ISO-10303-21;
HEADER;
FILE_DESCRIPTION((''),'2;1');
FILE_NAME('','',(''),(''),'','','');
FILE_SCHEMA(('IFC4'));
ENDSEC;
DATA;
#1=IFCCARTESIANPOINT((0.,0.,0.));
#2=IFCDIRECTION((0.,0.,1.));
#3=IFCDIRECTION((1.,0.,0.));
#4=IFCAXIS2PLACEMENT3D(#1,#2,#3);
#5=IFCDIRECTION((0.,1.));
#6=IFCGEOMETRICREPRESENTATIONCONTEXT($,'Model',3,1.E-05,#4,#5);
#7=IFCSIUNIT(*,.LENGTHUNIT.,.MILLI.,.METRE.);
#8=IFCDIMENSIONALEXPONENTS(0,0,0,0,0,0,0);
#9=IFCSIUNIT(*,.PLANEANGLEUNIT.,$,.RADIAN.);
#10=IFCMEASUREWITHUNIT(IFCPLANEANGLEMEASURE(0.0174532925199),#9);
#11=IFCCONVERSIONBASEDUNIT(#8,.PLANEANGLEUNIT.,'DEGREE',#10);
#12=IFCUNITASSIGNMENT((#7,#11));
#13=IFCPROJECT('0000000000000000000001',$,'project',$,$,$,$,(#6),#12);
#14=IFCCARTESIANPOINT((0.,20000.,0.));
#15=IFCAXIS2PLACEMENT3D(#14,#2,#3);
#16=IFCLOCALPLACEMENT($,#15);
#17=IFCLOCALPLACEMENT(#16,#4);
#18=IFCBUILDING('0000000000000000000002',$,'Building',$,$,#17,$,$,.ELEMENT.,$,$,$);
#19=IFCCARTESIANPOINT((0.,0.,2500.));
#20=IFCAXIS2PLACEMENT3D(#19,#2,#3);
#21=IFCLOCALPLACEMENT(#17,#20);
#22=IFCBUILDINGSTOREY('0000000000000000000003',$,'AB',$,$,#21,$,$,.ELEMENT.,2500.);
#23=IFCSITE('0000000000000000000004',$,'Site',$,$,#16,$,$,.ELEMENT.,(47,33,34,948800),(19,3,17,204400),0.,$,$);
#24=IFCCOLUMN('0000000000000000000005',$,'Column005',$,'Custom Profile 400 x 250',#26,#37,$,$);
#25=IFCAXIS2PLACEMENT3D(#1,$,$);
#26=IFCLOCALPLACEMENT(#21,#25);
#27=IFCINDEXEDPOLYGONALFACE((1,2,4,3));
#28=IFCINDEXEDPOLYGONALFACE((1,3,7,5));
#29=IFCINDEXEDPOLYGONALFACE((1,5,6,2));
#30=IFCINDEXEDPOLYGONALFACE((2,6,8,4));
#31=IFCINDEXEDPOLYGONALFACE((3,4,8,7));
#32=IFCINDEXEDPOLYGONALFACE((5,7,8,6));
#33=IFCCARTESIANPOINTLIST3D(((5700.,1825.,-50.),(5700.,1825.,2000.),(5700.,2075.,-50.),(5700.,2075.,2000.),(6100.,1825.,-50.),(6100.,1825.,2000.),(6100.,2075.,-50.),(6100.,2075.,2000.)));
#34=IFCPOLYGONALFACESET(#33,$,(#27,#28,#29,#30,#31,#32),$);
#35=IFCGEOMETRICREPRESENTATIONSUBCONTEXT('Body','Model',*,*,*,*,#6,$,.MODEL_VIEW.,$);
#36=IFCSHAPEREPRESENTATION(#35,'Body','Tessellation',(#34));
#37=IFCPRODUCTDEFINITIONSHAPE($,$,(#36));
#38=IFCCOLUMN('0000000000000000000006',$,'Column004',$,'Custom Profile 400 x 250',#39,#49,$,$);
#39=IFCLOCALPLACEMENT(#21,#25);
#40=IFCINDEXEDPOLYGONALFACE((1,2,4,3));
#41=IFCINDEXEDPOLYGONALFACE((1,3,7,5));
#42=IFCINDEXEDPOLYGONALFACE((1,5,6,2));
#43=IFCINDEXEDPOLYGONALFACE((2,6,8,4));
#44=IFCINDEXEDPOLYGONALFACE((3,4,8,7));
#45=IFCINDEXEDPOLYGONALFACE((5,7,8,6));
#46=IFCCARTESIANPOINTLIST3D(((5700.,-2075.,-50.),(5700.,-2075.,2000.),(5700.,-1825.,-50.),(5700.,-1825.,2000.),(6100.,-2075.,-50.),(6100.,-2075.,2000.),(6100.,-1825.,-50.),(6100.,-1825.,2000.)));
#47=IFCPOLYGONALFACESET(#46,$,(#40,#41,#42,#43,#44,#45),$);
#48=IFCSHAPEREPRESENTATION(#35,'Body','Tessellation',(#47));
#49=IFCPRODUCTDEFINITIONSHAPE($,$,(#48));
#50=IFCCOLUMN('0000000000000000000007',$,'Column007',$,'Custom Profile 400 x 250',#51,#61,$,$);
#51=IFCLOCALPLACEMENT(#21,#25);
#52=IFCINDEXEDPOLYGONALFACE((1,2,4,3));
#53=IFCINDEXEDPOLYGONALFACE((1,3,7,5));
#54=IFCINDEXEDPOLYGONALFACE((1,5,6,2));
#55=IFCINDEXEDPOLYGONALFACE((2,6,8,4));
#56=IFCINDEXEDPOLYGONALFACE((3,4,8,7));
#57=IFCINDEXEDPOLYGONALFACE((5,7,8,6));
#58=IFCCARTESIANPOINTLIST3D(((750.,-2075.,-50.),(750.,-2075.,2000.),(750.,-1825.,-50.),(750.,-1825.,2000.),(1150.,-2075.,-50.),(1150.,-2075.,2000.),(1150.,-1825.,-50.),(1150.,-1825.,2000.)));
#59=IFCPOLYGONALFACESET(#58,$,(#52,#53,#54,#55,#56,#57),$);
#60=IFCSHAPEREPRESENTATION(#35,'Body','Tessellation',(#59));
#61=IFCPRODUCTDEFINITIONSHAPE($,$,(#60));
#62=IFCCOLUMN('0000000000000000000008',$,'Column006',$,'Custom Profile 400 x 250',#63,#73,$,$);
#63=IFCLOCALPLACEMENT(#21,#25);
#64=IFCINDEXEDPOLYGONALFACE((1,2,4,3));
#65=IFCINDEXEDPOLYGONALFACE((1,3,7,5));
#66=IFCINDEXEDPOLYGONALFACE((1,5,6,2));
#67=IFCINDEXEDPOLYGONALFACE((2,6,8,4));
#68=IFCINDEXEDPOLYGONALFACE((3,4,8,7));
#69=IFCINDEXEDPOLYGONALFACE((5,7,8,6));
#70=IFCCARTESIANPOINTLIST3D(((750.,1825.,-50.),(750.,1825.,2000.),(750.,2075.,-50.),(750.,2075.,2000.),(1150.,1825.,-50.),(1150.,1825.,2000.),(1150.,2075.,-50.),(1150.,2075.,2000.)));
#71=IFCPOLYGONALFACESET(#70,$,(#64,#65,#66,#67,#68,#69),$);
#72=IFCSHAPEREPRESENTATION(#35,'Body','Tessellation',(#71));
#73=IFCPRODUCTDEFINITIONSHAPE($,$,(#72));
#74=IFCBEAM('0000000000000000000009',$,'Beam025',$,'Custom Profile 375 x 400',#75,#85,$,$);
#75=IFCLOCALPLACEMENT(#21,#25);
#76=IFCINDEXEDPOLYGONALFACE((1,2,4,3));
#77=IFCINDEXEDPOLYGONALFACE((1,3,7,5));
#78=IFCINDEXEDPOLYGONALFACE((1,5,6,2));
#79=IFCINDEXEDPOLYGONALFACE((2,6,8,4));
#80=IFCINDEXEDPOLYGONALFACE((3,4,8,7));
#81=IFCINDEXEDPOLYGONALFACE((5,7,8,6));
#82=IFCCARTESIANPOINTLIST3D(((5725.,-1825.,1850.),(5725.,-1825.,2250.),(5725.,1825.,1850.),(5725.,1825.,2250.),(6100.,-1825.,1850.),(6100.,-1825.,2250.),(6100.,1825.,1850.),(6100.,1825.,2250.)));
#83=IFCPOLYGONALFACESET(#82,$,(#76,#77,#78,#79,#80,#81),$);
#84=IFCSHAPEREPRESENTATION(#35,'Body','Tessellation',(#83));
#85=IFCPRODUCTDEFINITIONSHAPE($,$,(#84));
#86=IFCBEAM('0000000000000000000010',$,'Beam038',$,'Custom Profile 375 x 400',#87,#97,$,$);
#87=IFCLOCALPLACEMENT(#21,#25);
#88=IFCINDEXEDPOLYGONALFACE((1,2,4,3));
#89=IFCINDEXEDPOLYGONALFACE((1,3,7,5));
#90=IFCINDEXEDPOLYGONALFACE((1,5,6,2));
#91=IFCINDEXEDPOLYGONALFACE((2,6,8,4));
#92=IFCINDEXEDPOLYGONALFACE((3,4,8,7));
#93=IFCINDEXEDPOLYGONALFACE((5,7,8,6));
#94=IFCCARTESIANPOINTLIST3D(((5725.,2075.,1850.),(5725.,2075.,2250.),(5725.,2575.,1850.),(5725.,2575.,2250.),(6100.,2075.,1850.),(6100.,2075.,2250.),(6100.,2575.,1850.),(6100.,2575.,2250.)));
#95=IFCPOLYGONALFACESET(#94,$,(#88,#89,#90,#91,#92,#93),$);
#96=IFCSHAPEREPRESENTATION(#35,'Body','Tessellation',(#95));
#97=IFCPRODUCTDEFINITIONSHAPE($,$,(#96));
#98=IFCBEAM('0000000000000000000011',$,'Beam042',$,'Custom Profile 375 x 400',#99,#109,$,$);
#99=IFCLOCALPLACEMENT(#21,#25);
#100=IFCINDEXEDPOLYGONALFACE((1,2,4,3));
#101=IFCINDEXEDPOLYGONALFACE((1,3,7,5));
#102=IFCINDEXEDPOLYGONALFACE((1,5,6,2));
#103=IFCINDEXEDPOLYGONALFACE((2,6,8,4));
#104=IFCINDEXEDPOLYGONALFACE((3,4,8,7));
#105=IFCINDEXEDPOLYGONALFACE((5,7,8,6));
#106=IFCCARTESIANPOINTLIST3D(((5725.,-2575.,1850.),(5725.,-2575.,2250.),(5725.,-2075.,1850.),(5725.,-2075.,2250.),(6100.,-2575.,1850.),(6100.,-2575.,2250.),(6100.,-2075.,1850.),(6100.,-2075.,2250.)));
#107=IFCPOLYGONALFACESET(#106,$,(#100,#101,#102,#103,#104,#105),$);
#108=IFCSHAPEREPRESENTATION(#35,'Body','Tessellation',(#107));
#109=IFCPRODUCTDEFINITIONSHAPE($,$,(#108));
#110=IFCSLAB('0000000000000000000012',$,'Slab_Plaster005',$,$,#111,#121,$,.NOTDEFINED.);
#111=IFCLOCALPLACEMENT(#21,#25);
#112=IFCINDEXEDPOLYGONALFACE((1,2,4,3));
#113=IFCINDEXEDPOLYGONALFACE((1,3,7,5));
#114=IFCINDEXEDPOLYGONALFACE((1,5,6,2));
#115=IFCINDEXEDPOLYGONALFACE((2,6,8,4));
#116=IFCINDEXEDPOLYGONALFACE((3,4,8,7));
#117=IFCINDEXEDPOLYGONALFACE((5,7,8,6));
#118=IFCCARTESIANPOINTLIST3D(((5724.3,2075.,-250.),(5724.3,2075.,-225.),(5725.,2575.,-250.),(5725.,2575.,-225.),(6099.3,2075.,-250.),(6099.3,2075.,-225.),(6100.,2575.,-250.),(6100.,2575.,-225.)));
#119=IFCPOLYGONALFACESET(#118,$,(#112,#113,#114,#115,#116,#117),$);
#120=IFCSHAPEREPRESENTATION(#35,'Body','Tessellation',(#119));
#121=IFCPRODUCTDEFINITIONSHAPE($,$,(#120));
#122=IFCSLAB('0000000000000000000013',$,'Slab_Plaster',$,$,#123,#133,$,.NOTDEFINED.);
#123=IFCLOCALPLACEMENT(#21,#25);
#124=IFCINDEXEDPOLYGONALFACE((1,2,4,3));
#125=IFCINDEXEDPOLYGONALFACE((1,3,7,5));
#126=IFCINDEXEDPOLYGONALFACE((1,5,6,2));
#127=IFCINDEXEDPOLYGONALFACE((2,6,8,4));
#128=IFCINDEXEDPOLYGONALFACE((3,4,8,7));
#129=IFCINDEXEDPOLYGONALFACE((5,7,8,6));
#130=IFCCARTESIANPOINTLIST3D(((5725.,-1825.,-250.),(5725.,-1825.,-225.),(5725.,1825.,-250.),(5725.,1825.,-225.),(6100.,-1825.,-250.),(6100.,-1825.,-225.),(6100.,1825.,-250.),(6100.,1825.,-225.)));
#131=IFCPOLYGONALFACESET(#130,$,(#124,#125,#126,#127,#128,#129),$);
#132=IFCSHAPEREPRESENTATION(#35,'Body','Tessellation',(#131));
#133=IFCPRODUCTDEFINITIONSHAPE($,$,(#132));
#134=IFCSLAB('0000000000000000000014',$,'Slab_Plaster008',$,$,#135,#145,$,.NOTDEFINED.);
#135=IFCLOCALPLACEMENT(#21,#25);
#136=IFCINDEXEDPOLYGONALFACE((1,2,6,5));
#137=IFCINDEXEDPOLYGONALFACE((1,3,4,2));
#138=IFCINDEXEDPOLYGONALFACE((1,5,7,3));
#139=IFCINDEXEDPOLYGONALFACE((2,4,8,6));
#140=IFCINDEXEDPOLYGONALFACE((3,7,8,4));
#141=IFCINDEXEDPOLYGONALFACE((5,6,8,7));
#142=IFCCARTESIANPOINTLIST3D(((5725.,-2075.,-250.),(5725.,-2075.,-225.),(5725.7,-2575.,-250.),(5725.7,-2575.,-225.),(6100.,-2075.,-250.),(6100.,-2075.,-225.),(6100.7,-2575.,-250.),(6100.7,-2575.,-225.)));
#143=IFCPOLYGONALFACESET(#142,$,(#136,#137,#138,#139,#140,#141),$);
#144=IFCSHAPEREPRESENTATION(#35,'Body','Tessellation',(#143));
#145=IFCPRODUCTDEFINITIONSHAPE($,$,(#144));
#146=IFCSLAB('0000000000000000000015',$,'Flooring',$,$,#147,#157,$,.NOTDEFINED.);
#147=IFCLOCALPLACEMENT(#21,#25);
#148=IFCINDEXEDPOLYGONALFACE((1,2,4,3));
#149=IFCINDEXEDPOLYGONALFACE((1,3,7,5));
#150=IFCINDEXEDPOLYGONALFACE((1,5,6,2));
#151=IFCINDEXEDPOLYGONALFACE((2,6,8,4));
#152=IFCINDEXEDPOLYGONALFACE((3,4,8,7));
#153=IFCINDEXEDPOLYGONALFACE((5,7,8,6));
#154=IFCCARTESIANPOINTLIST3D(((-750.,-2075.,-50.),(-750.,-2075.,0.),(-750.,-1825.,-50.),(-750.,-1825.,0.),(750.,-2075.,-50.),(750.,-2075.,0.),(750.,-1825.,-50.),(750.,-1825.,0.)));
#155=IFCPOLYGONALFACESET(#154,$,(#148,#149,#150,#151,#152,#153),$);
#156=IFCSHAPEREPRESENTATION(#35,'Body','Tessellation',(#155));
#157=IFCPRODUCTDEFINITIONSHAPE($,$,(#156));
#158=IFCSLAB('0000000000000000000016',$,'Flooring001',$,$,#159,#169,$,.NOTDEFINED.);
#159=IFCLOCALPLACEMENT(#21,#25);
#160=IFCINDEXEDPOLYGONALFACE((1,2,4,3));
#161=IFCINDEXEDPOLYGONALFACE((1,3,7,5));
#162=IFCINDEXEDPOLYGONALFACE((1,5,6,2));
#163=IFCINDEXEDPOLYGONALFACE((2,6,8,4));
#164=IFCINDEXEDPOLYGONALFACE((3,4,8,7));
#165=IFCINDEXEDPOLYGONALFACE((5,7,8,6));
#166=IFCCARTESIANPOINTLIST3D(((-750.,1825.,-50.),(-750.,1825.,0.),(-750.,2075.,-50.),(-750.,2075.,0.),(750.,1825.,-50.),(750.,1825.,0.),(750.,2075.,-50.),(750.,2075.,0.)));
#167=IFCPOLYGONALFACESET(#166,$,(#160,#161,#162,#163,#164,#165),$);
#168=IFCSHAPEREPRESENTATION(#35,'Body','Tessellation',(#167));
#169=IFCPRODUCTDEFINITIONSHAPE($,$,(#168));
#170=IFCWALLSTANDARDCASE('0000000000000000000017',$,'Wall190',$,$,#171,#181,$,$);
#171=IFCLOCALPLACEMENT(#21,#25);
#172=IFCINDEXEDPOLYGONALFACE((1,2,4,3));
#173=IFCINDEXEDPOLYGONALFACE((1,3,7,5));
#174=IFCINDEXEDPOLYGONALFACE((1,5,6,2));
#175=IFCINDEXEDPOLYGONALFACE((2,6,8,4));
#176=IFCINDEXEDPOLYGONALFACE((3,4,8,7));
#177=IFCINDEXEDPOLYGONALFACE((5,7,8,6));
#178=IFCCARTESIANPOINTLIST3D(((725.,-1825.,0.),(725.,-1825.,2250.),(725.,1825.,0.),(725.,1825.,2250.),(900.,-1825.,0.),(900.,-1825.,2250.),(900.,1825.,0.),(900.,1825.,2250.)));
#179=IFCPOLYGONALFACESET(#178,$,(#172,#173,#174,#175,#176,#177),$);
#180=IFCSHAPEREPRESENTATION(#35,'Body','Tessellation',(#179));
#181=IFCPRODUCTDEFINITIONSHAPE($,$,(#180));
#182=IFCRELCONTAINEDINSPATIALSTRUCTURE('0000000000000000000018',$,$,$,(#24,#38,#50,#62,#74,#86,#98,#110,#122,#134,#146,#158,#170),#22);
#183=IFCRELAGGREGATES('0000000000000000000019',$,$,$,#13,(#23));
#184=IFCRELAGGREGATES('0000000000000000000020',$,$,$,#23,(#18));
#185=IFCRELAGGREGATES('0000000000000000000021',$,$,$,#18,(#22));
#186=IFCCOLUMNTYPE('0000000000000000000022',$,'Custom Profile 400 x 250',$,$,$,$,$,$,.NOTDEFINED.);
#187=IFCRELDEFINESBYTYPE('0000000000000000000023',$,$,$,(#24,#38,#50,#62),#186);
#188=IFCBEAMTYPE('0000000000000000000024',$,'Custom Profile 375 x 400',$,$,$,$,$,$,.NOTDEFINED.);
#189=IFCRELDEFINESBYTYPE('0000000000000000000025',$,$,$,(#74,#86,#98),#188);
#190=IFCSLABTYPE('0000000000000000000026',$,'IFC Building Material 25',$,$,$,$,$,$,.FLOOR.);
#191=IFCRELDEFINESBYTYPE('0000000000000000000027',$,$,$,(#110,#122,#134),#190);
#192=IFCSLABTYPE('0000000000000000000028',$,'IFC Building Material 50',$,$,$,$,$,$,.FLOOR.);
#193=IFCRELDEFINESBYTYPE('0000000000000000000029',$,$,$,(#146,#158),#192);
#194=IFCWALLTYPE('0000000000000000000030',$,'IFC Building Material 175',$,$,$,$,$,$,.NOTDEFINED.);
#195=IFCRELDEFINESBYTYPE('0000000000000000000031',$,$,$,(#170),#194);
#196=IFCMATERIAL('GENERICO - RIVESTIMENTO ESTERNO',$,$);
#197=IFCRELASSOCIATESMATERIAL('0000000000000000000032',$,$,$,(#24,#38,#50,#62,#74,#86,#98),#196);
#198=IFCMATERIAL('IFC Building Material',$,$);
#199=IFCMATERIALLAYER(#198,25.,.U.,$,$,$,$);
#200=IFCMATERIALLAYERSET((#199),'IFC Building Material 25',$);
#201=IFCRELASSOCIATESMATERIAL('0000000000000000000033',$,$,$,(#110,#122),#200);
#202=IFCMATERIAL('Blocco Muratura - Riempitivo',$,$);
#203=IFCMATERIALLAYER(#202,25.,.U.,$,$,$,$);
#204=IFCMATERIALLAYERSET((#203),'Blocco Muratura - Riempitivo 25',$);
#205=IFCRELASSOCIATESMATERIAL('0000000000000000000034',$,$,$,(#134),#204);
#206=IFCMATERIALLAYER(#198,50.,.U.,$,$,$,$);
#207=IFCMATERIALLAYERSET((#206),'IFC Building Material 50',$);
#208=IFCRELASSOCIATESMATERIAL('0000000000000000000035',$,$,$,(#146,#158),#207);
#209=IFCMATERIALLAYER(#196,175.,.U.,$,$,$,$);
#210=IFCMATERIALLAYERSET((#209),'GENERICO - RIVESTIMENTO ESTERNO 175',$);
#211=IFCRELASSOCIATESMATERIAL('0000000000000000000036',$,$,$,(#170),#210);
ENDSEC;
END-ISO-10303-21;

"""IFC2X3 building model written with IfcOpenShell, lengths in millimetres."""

from ifc_helpers import new_model, entity, si_unit, converted_unit, direction, frame, frame_2d, origin_with_axes, origin_2d_with_axis, place, context, subcontext, project, spatial, polyline, rectangle, outline, extrude, material, layer, layer_set, layer_usage, type_object, element, save


model = new_model("IFC2X3")

# Units and contexts
model_context = context("Model", 3, precision=1e-05, world=origin_with_axes(), true_north=direction((0.0, 1.0)))
body_context = subcontext(model_context, "Body", "Model", "MODEL_VIEW")
ifc_project = project(units=[si_unit("LENGTHUNIT", "METRE", prefix="MILLI"), converted_unit("PLANEANGLEUNIT", "DEGREE", entity("IfcPlaneAngleMeasure", 0.0174532925199), si_unit("PLANEANGLEUNIT", "RADIAN"), dimensions=[0, 0, 0, 0, 0, 0, 0])], contexts=[model_context])

# Site, building, storey
site_placement = place(None, frame((0.0, 20000.0, 0.0), z_axis=(0.0, 0.0, 1.0), x_axis=(1.0, 0.0, 0.0)))
site = spatial("IfcSite", under=ifc_project, at=site_placement, Name="Site", CompositionType="ELEMENT", RefLatitude=(47, 33, 34, 948800), RefLongitude=(19, 3, 17, 204400), RefElevation=0.0)
building_placement = place(site_placement, origin_with_axes())
building = spatial("IfcBuilding", under=site, at=building_placement, Name="Building", CompositionType="ELEMENT")
storey_placement = place(building_placement, frame((0.0, 0.0, 2500.0), z_axis=(0.0, 0.0, 1.0), x_axis=(1.0, 0.0, 0.0)))
storey = spatial("IfcBuildingStorey", under=building, at=storey_placement, Name="AB", CompositionType="ELEMENT", Elevation=2500.0)

# Columns
ifc_material_1 = material(Name="GENERICO - RIVESTIMENTO ESTERNO")
column_type = type_object("IfcColumnType", Name="Custom Profile 400 x 250", PredefinedType="NOTDEFINED")
for number, where, z_axis, x_axis, name in (
    (1, (5900.0, 1950.0, -50.0), (0.0, 0.0, 1.0), (1.0, 0.0, 0.0), "Column005"),
    (2, (5900.0, -1950.0, -50.0), (0.0, 0.0, 1.0), (1.0, 0.0, 0.0), "Column004"),
    (3, (950.0, -1950.0, -50.0), (0.0, 0.0, 1.0), (1.0, 0.0, 0.0), "Column007"),
    (4, (950.0, 1950.0, -50.0), (0.0, 0.0, 1.0), (1.0, 0.0, 0.0), "Column006"),
):
    element("IfcColumn", number, at=place(storey_placement, frame(where, z_axis=z_axis, x_axis=x_axis)), inside=storey, type_object=column_type, material=ifc_material_1, Name=name, ObjectType="Custom Profile 400 x 250", context=body_context, shape_type="SweptSolid", body=[
        extrude(rectangle(XDim=400.0, YDim=250.0, at=origin_2d_with_axis()), origin_with_axes(), (0.0, 0.0, 1.0), 2050.0),
    ])

# Beams
beam_type = type_object("IfcBeamType", Name="Custom Profile 375 x 400", PredefinedType="NOTDEFINED")
beam_placement = place(storey_placement, frame((5912.5, -1825.0, 2250.0), z_axis=(0.0, 0.0, 1.0), x_axis=(1.0, 0.0, 0.0)))
element("IfcBeam", 5, at=beam_placement, inside=storey, type_object=beam_type, material=ifc_material_1, Name="Beam025", ObjectType="Custom Profile 375 x 400", context=body_context, shape_type="SweptSolid", body=[
    extrude(rectangle(XDim=400.0, YDim=375.0, at=frame_2d((-200.0, 0.0), x_axis=(1.0, 0.0))), frame((0.0, 0.0, 0.0), z_axis=(0.0, 1.0, 0.0), x_axis=(0.0, 0.0, 1.0)), (0.0, 0.0, 1.0), 3650.0),
])
for number, where, z_axis, x_axis, name in (
    (6, (5912.5, 2575.0, 2250.0), (0.0, 0.0, 1.0), (-1.0, 0.0, 0.0), "Beam038"),
    (7, (5912.5, -2075.0, 2250.0), (0.0, 0.0, 1.0), (-1.0, 0.0, 0.0), "Beam042"),
):
    element("IfcBeam", number, at=place(storey_placement, frame(where, z_axis=z_axis, x_axis=x_axis)), inside=storey, type_object=beam_type, material=ifc_material_1, Name=name, ObjectType="Custom Profile 375 x 400", context=body_context, shape_type="SweptSolid", body=[
        extrude(rectangle(XDim=400.0, YDim=375.0, at=frame_2d((-200.0, 0.0), x_axis=(1.0, 0.0))), frame((0.0, 0.0, 0.0), z_axis=(0.0, 1.0, 0.0), x_axis=(0.0, 0.0, 1.0)), (0.0, 0.0, 1.0), 500.0),
    ])

# Slabs
ifc_material_2 = material(Name="IFC Building Material")
ifc_layer_1 = layer(ifc_material_2, 25.0, ventilated="UNKNOWN")
ifc_layer_set_1 = layer_set([ifc_layer_1], Name="IFC Building Material 25")
ifc_layer_usage_1 = layer_usage(ifc_layer_set_1, "AXIS3", "NEGATIVE", 25.0)
slab_type_1 = type_object("IfcSlabType", Name="IFC Building Material 25", PredefinedType="FLOOR")
slab_1_placement = place(storey_placement, frame((6099.3, 2075.0, -225.0), z_axis=(0.0, 0.0, 1.0), x_axis=(1.0, 0.0, 0.0)))
element("IfcSlab", 8, at=slab_1_placement, inside=storey, type_object=slab_type_1, material=ifc_layer_usage_1, Name="Slab_Plaster005", PredefinedType="NOTDEFINED", context=body_context, shape_type="SweptSolid", body=[
    extrude(outline(polyline([(0.0, 0.0), (0.7, 500.0), (-374.3, 500.0), (-375.0, 0.0), (0.0, 0.0)])), frame((0.0, 0.0, -25.0), z_axis=(0.0, 0.0, 1.0), x_axis=(1.0, 0.0, 0.0)), (0.0, 0.0, 1.0), 25.0),
])
ifc_layer_usage_2 = layer_usage(ifc_layer_set_1, "AXIS3", "NEGATIVE", 25.0)
slab_2_placement = place(storey_placement, frame((6100.0, -1825.0, -225.0), z_axis=(0.0, 0.0, 1.0), x_axis=(1.0, 0.0, 0.0)))
element("IfcSlab", 9, at=slab_2_placement, inside=storey, type_object=slab_type_1, material=ifc_layer_usage_2, Name="Slab_Plaster", PredefinedType="NOTDEFINED", context=body_context, shape_type="SweptSolid", body=[
    extrude(outline(polyline([(0.0, 0.0), (0.0, 3650.0), (-375.0, 3650.0), (-375.0, 0.0), (0.0, 0.0)])), frame((0.0, 0.0, -25.0), z_axis=(0.0, 0.0, 1.0), x_axis=(1.0, 0.0, 0.0)), (0.0, 0.0, 1.0), 25.0),
])
ifc_material_3 = material(Name="Blocco Muratura - Riempitivo")
ifc_layer_2 = layer(ifc_material_3, 25.0, ventilated="UNKNOWN")
ifc_layer_set_2 = layer_set([ifc_layer_2], Name="Blocco Muratura - Riempitivo 25")
ifc_layer_usage_3 = layer_usage(ifc_layer_set_2, "AXIS3", "NEGATIVE", 25.0)
slab_3_placement = place(storey_placement, frame((6100.0, -2075.0, -225.0), z_axis=(0.0, 0.0, 1.0), x_axis=(1.0, 0.0, 0.0)))
element("IfcSlab", 10, at=slab_3_placement, inside=storey, type_object=slab_type_1, material=ifc_layer_usage_3, Name="Slab_Plaster008", PredefinedType="NOTDEFINED", context=body_context, shape_type="SweptSolid", body=[
    extrude(outline(polyline([(0.0, 0.0), (-375.0, 0.0), (-374.3, -500.0), (0.7, -500.0), (0.0, 0.0)])), frame((0.0, 0.0, -25.0), z_axis=(0.0, 0.0, 1.0), x_axis=(1.0, 0.0, 0.0)), (0.0, 0.0, 1.0), 25.0),
])
ifc_layer_3 = layer(ifc_material_2, 50.0, ventilated="UNKNOWN")
ifc_layer_set_3 = layer_set([ifc_layer_3], Name="IFC Building Material 50")
ifc_layer_usage_4 = layer_usage(ifc_layer_set_3, "AXIS3", "NEGATIVE", 50.0)
slab_type_2 = type_object("IfcSlabType", Name="IFC Building Material 50", PredefinedType="FLOOR")
slab_4_placement = place(storey_placement, frame((-750.0, -2075.0, 0.0), z_axis=(0.0, 0.0, 1.0), x_axis=(1.0, 0.0, 0.0)))
element("IfcSlab", 11, at=slab_4_placement, inside=storey, type_object=slab_type_2, material=ifc_layer_usage_4, Name="Flooring", PredefinedType="NOTDEFINED", context=body_context, shape_type="SweptSolid", body=[
    extrude(outline(polyline([(0.0, 0.0), (1500.0, 0.0), (1500.0, 250.0), (0.0, 250.0), (0.0, 0.0)])), frame((0.0, 0.0, -50.0), z_axis=(0.0, 0.0, 1.0), x_axis=(1.0, 0.0, 0.0)), (0.0, 0.0, 1.0), 50.0),
])
ifc_layer_usage_5 = layer_usage(ifc_layer_set_3, "AXIS3", "NEGATIVE", 50.0)
slab_5_placement = place(storey_placement, frame((-750.0, 1825.0, 0.0), z_axis=(0.0, 0.0, 1.0), x_axis=(1.0, 0.0, 0.0)))
element("IfcSlab", 12, at=slab_5_placement, inside=storey, type_object=slab_type_2, material=ifc_layer_usage_5, Name="Flooring001", PredefinedType="NOTDEFINED", context=body_context, shape_type="SweptSolid", body=[
    extrude(outline(polyline([(0.0, 0.0), (1500.0, 0.0), (1500.0, 250.0), (0.0, 250.0), (0.0, 0.0)])), frame((0.0, 0.0, -50.0), z_axis=(0.0, 0.0, 1.0), x_axis=(1.0, 0.0, 0.0)), (0.0, 0.0, 1.0), 50.0),
])

# Wall
ifc_layer_4 = layer(ifc_material_1, 175.0, ventilated="UNKNOWN")
ifc_layer_set_4 = layer_set([ifc_layer_4], Name="GENERICO - RIVESTIMENTO ESTERNO 175")
ifc_layer_usage_6 = layer_usage(ifc_layer_set_4, "AXIS2", "POSITIVE", -175.0)
wall_type_1 = type_object("IfcWallType", Name="IFC Building Material 175", PredefinedType="NOTDEFINED")
wall_1_placement = place(storey_placement, frame((900.0, 1825.0, 0.0), z_axis=(0.0, 0.0, 1.0), x_axis=(0.0, -1.0, 0.0)))
element("IfcWallStandardCase", 13, at=wall_1_placement, inside=storey, type_object=wall_type_1, material=ifc_layer_usage_6, Name="Wall190", context=body_context, shape_type="SweptSolid", body=[
    extrude(outline(polyline([(0.0, -175.0), (3650.0, -175.0), (3650.0, 0.0), (0.0, 0.0), (0.0, -175.0)])), origin_with_axes(), (0.0, 0.0, 1.0), 2250.0),
])

save(model, "model.ifc")
